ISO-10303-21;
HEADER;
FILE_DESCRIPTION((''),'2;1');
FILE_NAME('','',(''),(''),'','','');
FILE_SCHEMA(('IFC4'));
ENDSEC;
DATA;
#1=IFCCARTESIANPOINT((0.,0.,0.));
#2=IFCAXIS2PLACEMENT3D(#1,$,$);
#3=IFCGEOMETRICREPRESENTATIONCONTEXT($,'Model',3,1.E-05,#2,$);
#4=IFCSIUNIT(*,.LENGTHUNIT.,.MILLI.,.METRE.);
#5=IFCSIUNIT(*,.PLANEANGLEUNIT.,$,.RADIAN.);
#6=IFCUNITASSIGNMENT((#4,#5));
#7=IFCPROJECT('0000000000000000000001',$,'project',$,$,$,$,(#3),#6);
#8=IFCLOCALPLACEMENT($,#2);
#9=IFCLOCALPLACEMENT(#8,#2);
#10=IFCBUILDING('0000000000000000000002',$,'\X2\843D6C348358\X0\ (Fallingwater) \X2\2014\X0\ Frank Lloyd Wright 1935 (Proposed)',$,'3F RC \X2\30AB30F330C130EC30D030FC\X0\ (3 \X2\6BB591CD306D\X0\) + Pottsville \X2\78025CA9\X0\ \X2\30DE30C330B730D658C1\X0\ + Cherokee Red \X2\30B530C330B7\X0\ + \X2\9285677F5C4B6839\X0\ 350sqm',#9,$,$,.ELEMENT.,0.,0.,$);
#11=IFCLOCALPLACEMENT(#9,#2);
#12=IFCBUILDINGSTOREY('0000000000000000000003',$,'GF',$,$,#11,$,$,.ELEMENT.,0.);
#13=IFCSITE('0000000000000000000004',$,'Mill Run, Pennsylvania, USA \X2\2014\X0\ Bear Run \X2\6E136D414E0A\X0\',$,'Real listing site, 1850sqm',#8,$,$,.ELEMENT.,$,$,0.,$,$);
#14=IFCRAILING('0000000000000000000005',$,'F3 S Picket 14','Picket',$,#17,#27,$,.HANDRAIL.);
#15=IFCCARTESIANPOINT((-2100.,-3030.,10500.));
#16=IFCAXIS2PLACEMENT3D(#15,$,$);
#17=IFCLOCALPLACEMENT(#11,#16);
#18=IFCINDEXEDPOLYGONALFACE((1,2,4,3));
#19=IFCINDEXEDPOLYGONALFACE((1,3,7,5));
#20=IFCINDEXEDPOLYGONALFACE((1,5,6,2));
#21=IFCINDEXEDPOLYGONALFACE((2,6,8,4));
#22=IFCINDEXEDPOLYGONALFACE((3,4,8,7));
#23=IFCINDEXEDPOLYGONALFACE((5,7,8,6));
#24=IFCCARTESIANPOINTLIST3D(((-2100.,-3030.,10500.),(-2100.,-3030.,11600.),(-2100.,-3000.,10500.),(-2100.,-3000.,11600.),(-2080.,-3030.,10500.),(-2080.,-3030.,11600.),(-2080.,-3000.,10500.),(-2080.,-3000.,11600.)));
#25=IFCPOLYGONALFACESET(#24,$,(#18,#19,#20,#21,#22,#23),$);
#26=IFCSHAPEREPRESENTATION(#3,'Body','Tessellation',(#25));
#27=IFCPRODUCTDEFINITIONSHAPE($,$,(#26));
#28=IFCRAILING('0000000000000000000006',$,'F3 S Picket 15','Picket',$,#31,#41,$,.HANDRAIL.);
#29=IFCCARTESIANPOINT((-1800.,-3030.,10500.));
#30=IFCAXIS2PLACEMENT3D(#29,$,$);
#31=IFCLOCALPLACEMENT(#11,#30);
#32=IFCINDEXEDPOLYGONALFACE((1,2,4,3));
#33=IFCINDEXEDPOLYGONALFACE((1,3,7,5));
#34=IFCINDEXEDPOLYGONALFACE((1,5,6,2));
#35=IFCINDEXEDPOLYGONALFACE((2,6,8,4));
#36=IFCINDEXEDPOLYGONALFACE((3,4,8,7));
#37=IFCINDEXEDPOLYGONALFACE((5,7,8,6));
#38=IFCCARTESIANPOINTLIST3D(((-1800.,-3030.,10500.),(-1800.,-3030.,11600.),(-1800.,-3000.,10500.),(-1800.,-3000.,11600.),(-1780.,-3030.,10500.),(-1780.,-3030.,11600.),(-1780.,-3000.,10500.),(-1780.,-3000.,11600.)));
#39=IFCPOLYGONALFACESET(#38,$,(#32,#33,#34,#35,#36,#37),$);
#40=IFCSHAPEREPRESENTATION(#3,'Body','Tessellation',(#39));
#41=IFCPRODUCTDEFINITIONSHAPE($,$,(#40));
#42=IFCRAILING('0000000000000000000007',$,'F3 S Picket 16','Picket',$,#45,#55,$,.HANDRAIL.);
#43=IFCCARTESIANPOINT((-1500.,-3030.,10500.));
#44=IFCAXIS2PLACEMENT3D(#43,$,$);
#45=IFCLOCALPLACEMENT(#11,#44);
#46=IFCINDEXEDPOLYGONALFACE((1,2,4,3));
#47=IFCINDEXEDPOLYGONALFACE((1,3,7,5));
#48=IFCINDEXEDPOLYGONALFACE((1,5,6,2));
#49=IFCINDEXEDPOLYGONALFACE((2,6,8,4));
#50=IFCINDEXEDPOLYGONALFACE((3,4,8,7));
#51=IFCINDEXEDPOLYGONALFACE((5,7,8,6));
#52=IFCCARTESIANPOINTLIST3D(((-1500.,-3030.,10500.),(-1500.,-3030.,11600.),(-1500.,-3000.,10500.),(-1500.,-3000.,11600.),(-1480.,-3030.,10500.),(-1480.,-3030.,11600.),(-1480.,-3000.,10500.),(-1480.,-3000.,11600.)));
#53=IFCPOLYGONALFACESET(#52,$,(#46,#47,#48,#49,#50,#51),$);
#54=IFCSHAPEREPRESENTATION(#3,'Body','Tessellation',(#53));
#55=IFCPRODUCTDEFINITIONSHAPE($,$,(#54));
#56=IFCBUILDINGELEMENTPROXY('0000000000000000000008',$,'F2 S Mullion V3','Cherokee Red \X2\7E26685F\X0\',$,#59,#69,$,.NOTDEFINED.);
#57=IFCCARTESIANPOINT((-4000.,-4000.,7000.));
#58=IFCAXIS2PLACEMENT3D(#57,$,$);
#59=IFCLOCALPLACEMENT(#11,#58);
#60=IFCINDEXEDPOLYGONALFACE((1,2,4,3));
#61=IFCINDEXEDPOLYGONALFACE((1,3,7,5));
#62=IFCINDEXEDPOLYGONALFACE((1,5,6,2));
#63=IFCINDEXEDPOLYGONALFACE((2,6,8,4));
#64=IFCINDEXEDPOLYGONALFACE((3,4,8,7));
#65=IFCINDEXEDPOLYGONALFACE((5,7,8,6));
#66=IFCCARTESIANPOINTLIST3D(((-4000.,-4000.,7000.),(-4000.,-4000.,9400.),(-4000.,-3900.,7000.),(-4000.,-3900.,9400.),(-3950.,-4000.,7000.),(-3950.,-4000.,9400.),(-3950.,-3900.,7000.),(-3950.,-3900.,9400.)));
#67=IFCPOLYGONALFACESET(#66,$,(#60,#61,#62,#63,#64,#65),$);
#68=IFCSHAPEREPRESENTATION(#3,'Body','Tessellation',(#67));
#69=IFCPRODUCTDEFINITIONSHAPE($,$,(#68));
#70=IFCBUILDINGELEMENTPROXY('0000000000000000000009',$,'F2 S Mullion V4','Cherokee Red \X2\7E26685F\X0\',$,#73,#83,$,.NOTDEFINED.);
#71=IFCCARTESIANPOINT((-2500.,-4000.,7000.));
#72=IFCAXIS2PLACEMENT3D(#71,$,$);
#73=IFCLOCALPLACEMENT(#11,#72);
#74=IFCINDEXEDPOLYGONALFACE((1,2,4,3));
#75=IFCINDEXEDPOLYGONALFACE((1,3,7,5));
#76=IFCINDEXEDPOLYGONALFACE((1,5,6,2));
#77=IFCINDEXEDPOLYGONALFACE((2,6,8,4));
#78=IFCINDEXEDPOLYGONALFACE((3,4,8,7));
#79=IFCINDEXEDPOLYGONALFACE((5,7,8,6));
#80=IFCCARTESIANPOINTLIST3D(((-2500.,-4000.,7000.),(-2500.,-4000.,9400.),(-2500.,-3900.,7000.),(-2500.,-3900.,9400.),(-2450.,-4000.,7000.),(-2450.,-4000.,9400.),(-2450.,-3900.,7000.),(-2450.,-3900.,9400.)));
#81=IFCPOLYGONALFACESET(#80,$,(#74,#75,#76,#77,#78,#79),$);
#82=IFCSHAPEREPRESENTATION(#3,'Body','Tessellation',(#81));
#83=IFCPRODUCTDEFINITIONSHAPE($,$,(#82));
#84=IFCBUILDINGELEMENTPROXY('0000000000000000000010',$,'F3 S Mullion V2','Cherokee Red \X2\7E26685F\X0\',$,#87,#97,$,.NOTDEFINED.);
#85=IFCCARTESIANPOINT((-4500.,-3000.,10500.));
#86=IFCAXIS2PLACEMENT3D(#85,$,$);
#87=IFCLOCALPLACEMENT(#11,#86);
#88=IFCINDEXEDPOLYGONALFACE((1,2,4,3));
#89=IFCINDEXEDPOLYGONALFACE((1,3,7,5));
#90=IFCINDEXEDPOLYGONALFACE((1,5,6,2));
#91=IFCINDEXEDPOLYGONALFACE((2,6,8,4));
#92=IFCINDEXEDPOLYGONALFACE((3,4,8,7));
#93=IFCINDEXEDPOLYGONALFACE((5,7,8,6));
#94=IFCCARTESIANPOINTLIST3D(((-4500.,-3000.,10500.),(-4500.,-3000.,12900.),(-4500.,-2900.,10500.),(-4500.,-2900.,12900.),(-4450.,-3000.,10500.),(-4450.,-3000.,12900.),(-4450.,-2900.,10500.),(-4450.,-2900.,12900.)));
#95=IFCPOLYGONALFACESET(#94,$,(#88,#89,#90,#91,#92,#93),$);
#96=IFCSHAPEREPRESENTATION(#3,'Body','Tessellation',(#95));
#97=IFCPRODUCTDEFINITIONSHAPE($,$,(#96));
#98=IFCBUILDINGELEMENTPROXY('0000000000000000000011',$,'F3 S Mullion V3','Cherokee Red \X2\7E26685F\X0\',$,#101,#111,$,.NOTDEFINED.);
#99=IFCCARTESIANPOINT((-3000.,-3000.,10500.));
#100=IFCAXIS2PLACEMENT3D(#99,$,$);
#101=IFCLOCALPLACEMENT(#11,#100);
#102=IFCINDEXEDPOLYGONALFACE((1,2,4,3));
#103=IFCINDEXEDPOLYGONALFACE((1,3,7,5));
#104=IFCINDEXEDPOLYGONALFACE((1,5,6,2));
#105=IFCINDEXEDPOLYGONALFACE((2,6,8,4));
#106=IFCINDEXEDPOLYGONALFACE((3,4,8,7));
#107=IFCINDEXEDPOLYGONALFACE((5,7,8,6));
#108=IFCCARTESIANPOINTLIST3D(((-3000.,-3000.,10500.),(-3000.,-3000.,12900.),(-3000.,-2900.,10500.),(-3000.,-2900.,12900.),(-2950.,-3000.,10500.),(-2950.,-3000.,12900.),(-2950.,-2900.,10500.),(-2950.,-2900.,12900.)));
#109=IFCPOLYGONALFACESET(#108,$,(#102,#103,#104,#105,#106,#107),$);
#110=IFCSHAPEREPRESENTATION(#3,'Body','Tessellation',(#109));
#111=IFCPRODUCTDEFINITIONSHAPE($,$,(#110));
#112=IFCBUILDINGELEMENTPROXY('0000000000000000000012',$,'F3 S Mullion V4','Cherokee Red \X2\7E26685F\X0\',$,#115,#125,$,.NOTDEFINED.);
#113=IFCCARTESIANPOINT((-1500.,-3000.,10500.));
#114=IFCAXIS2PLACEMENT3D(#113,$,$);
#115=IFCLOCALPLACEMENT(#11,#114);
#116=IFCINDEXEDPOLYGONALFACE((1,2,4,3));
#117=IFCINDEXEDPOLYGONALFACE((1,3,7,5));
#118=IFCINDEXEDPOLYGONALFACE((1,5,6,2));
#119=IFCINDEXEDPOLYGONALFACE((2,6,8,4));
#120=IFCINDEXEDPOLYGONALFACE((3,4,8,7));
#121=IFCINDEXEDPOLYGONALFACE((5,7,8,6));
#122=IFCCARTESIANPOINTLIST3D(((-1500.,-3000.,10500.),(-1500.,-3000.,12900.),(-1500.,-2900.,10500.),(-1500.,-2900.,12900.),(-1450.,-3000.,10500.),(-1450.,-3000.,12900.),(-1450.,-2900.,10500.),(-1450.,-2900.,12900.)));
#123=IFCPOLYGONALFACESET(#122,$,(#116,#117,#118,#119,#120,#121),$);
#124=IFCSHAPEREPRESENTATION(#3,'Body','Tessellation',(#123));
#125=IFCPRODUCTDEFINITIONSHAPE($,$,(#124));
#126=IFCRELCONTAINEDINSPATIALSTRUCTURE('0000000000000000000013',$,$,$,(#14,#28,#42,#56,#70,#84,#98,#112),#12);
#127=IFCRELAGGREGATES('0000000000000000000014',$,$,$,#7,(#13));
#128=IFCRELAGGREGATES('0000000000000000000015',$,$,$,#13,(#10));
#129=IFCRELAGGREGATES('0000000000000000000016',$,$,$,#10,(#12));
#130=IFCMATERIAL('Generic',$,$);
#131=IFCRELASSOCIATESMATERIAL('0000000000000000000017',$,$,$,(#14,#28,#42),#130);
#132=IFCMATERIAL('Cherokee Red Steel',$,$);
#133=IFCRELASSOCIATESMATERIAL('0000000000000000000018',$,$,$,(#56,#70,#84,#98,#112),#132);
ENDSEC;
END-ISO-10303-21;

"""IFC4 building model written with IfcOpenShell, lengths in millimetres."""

from ifc_helpers import new_model, si_unit, frame, frame_2d, origin, place, context, project, spatial, rectangle, extrude, material, element, save


model = new_model("IFC4")

# Units and contexts
model_context = context("Model", 3, precision=1e-05, world=origin())
ifc_project = project(units=[si_unit("LENGTHUNIT", "METRE", prefix="MILLI"), si_unit("PLANEANGLEUNIT", "RADIAN")], contexts=[model_context])

# Site, building, storey
site_placement = place(None, origin())
site = spatial("IfcSite", under=ifc_project, at=site_placement, Name="Mill Run, Pennsylvania, USA — Bear Run 渓流上", ObjectType="Real listing site, 1850sqm", CompositionType="ELEMENT", RefElevation=0.0)
building_placement = place(site_placement, origin())
building = spatial("IfcBuilding", under=site, at=building_placement, Name="落水荘 (Fallingwater) — Frank Lloyd Wright 1935 (Proposed)", ObjectType="3F RC カンチレバー (3 段重ね) + Pottsville 砂岩 マッシブ壁 + Cherokee Red サッシ + 銅板屋根 350sqm", CompositionType="ELEMENT", ElevationOfRefHeight=0.0, ElevationOfTerrain=0.0)
storey_placement = place(building_placement, origin())
storey = spatial("IfcBuildingStorey", under=building, at=storey_placement, Name="GF", CompositionType="ELEMENT", Elevation=0.0)

# Shared definitions
ifc_material_1 = material(Name="Cherokee Red Steel")

# Railings
ifc_material_2 = material(Name="Generic")
railing_1_placement = place(storey_placement, frame((-2100.0, -3030.0, 10500.0)))
element("IfcRailing", 1, at=railing_1_placement, inside=storey, material=ifc_material_2, Name="F3 S Picket 14", Description="Picket", PredefinedType="HANDRAIL", context=model_context, shape_type="SweptSolid", body=[
    extrude(rectangle(XDim=20.0, YDim=30.0, at=frame_2d((10.0, 15.0))), frame((-2100.0, -3030.0, 10500.0)), (0.0, 0.0, 1.0), 1100.0),
])
railing_2_placement = place(storey_placement, frame((-1800.0, -3030.0, 10500.0)))
element("IfcRailing", 2, at=railing_2_placement, inside=storey, material=ifc_material_2, Name="F3 S Picket 15", Description="Picket", PredefinedType="HANDRAIL", context=model_context, shape_type="SweptSolid", body=[
    extrude(rectangle(XDim=20.0, YDim=30.0, at=frame_2d((10.0, 15.0))), frame((-1800.0, -3030.0, 10500.0)), (0.0, 0.0, 1.0), 1100.0),
])
railing_3_placement = place(storey_placement, frame((-1500.0, -3030.0, 10500.0)))
element("IfcRailing", 3, at=railing_3_placement, inside=storey, material=ifc_material_2, Name="F3 S Picket 16", Description="Picket", PredefinedType="HANDRAIL", context=model_context, shape_type="SweptSolid", body=[
    extrude(rectangle(XDim=20.0, YDim=30.0, at=frame_2d((10.0, 15.0))), frame((-1500.0, -3030.0, 10500.0)), (0.0, 0.0, 1.0), 1100.0),
])

# Building element proxies
proxy_1_placement = place(storey_placement, frame((-4000.0, -4000.0, 7000.0)))
element("IfcBuildingElementProxy", 4, at=proxy_1_placement, inside=storey, material=ifc_material_1, Name="F2 S Mullion V3", Description="Cherokee Red 縦桟", PredefinedType="NOTDEFINED", context=model_context, shape_type="SweptSolid", body=[
    extrude(rectangle(XDim=50.0, YDim=100.0, at=frame_2d((25.0, 50.0))), frame((-4000.0, -4000.0, 7000.0)), (0.0, 0.0, 1.0), 2400.0),
])
proxy_2_placement = place(storey_placement, frame((-2500.0, -4000.0, 7000.0)))
element("IfcBuildingElementProxy", 5, at=proxy_2_placement, inside=storey, material=ifc_material_1, Name="F2 S Mullion V4", Description="Cherokee Red 縦桟", PredefinedType="NOTDEFINED", context=model_context, shape_type="SweptSolid", body=[
    extrude(rectangle(XDim=50.0, YDim=100.0, at=frame_2d((25.0, 50.0))), frame((-2500.0, -4000.0, 7000.0)), (0.0, 0.0, 1.0), 2400.0),
])
proxy_3_placement = place(storey_placement, frame((-4500.0, -3000.0, 10500.0)))
element("IfcBuildingElementProxy", 6, at=proxy_3_placement, inside=storey, material=ifc_material_1, Name="F3 S Mullion V2", Description="Cherokee Red 縦桟", PredefinedType="NOTDEFINED", context=model_context, shape_type="SweptSolid", body=[
    extrude(rectangle(XDim=50.0, YDim=100.0, at=frame_2d((25.0, 50.0))), frame((-4500.0, -3000.0, 10500.0)), (0.0, 0.0, 1.0), 2400.0),
])
proxy_4_placement = place(storey_placement, frame((-3000.0, -3000.0, 10500.0)))
element("IfcBuildingElementProxy", 7, at=proxy_4_placement, inside=storey, material=ifc_material_1, Name="F3 S Mullion V3", Description="Cherokee Red 縦桟", PredefinedType="NOTDEFINED", context=model_context, shape_type="SweptSolid", body=[
    extrude(rectangle(XDim=50.0, YDim=100.0, at=frame_2d((25.0, 50.0))), frame((-3000.0, -3000.0, 10500.0)), (0.0, 0.0, 1.0), 2400.0),
])
proxy_5_placement = place(storey_placement, frame((-1500.0, -3000.0, 10500.0)))
element("IfcBuildingElementProxy", 8, at=proxy_5_placement, inside=storey, material=ifc_material_1, Name="F3 S Mullion V4", Description="Cherokee Red 縦桟", PredefinedType="NOTDEFINED", context=model_context, shape_type="SweptSolid", body=[
    extrude(rectangle(XDim=50.0, YDim=100.0, at=frame_2d((25.0, 50.0))), frame((-1500.0, -3000.0, 10500.0)), (0.0, 0.0, 1.0), 2400.0),
])

save(model, "model.ifc")
